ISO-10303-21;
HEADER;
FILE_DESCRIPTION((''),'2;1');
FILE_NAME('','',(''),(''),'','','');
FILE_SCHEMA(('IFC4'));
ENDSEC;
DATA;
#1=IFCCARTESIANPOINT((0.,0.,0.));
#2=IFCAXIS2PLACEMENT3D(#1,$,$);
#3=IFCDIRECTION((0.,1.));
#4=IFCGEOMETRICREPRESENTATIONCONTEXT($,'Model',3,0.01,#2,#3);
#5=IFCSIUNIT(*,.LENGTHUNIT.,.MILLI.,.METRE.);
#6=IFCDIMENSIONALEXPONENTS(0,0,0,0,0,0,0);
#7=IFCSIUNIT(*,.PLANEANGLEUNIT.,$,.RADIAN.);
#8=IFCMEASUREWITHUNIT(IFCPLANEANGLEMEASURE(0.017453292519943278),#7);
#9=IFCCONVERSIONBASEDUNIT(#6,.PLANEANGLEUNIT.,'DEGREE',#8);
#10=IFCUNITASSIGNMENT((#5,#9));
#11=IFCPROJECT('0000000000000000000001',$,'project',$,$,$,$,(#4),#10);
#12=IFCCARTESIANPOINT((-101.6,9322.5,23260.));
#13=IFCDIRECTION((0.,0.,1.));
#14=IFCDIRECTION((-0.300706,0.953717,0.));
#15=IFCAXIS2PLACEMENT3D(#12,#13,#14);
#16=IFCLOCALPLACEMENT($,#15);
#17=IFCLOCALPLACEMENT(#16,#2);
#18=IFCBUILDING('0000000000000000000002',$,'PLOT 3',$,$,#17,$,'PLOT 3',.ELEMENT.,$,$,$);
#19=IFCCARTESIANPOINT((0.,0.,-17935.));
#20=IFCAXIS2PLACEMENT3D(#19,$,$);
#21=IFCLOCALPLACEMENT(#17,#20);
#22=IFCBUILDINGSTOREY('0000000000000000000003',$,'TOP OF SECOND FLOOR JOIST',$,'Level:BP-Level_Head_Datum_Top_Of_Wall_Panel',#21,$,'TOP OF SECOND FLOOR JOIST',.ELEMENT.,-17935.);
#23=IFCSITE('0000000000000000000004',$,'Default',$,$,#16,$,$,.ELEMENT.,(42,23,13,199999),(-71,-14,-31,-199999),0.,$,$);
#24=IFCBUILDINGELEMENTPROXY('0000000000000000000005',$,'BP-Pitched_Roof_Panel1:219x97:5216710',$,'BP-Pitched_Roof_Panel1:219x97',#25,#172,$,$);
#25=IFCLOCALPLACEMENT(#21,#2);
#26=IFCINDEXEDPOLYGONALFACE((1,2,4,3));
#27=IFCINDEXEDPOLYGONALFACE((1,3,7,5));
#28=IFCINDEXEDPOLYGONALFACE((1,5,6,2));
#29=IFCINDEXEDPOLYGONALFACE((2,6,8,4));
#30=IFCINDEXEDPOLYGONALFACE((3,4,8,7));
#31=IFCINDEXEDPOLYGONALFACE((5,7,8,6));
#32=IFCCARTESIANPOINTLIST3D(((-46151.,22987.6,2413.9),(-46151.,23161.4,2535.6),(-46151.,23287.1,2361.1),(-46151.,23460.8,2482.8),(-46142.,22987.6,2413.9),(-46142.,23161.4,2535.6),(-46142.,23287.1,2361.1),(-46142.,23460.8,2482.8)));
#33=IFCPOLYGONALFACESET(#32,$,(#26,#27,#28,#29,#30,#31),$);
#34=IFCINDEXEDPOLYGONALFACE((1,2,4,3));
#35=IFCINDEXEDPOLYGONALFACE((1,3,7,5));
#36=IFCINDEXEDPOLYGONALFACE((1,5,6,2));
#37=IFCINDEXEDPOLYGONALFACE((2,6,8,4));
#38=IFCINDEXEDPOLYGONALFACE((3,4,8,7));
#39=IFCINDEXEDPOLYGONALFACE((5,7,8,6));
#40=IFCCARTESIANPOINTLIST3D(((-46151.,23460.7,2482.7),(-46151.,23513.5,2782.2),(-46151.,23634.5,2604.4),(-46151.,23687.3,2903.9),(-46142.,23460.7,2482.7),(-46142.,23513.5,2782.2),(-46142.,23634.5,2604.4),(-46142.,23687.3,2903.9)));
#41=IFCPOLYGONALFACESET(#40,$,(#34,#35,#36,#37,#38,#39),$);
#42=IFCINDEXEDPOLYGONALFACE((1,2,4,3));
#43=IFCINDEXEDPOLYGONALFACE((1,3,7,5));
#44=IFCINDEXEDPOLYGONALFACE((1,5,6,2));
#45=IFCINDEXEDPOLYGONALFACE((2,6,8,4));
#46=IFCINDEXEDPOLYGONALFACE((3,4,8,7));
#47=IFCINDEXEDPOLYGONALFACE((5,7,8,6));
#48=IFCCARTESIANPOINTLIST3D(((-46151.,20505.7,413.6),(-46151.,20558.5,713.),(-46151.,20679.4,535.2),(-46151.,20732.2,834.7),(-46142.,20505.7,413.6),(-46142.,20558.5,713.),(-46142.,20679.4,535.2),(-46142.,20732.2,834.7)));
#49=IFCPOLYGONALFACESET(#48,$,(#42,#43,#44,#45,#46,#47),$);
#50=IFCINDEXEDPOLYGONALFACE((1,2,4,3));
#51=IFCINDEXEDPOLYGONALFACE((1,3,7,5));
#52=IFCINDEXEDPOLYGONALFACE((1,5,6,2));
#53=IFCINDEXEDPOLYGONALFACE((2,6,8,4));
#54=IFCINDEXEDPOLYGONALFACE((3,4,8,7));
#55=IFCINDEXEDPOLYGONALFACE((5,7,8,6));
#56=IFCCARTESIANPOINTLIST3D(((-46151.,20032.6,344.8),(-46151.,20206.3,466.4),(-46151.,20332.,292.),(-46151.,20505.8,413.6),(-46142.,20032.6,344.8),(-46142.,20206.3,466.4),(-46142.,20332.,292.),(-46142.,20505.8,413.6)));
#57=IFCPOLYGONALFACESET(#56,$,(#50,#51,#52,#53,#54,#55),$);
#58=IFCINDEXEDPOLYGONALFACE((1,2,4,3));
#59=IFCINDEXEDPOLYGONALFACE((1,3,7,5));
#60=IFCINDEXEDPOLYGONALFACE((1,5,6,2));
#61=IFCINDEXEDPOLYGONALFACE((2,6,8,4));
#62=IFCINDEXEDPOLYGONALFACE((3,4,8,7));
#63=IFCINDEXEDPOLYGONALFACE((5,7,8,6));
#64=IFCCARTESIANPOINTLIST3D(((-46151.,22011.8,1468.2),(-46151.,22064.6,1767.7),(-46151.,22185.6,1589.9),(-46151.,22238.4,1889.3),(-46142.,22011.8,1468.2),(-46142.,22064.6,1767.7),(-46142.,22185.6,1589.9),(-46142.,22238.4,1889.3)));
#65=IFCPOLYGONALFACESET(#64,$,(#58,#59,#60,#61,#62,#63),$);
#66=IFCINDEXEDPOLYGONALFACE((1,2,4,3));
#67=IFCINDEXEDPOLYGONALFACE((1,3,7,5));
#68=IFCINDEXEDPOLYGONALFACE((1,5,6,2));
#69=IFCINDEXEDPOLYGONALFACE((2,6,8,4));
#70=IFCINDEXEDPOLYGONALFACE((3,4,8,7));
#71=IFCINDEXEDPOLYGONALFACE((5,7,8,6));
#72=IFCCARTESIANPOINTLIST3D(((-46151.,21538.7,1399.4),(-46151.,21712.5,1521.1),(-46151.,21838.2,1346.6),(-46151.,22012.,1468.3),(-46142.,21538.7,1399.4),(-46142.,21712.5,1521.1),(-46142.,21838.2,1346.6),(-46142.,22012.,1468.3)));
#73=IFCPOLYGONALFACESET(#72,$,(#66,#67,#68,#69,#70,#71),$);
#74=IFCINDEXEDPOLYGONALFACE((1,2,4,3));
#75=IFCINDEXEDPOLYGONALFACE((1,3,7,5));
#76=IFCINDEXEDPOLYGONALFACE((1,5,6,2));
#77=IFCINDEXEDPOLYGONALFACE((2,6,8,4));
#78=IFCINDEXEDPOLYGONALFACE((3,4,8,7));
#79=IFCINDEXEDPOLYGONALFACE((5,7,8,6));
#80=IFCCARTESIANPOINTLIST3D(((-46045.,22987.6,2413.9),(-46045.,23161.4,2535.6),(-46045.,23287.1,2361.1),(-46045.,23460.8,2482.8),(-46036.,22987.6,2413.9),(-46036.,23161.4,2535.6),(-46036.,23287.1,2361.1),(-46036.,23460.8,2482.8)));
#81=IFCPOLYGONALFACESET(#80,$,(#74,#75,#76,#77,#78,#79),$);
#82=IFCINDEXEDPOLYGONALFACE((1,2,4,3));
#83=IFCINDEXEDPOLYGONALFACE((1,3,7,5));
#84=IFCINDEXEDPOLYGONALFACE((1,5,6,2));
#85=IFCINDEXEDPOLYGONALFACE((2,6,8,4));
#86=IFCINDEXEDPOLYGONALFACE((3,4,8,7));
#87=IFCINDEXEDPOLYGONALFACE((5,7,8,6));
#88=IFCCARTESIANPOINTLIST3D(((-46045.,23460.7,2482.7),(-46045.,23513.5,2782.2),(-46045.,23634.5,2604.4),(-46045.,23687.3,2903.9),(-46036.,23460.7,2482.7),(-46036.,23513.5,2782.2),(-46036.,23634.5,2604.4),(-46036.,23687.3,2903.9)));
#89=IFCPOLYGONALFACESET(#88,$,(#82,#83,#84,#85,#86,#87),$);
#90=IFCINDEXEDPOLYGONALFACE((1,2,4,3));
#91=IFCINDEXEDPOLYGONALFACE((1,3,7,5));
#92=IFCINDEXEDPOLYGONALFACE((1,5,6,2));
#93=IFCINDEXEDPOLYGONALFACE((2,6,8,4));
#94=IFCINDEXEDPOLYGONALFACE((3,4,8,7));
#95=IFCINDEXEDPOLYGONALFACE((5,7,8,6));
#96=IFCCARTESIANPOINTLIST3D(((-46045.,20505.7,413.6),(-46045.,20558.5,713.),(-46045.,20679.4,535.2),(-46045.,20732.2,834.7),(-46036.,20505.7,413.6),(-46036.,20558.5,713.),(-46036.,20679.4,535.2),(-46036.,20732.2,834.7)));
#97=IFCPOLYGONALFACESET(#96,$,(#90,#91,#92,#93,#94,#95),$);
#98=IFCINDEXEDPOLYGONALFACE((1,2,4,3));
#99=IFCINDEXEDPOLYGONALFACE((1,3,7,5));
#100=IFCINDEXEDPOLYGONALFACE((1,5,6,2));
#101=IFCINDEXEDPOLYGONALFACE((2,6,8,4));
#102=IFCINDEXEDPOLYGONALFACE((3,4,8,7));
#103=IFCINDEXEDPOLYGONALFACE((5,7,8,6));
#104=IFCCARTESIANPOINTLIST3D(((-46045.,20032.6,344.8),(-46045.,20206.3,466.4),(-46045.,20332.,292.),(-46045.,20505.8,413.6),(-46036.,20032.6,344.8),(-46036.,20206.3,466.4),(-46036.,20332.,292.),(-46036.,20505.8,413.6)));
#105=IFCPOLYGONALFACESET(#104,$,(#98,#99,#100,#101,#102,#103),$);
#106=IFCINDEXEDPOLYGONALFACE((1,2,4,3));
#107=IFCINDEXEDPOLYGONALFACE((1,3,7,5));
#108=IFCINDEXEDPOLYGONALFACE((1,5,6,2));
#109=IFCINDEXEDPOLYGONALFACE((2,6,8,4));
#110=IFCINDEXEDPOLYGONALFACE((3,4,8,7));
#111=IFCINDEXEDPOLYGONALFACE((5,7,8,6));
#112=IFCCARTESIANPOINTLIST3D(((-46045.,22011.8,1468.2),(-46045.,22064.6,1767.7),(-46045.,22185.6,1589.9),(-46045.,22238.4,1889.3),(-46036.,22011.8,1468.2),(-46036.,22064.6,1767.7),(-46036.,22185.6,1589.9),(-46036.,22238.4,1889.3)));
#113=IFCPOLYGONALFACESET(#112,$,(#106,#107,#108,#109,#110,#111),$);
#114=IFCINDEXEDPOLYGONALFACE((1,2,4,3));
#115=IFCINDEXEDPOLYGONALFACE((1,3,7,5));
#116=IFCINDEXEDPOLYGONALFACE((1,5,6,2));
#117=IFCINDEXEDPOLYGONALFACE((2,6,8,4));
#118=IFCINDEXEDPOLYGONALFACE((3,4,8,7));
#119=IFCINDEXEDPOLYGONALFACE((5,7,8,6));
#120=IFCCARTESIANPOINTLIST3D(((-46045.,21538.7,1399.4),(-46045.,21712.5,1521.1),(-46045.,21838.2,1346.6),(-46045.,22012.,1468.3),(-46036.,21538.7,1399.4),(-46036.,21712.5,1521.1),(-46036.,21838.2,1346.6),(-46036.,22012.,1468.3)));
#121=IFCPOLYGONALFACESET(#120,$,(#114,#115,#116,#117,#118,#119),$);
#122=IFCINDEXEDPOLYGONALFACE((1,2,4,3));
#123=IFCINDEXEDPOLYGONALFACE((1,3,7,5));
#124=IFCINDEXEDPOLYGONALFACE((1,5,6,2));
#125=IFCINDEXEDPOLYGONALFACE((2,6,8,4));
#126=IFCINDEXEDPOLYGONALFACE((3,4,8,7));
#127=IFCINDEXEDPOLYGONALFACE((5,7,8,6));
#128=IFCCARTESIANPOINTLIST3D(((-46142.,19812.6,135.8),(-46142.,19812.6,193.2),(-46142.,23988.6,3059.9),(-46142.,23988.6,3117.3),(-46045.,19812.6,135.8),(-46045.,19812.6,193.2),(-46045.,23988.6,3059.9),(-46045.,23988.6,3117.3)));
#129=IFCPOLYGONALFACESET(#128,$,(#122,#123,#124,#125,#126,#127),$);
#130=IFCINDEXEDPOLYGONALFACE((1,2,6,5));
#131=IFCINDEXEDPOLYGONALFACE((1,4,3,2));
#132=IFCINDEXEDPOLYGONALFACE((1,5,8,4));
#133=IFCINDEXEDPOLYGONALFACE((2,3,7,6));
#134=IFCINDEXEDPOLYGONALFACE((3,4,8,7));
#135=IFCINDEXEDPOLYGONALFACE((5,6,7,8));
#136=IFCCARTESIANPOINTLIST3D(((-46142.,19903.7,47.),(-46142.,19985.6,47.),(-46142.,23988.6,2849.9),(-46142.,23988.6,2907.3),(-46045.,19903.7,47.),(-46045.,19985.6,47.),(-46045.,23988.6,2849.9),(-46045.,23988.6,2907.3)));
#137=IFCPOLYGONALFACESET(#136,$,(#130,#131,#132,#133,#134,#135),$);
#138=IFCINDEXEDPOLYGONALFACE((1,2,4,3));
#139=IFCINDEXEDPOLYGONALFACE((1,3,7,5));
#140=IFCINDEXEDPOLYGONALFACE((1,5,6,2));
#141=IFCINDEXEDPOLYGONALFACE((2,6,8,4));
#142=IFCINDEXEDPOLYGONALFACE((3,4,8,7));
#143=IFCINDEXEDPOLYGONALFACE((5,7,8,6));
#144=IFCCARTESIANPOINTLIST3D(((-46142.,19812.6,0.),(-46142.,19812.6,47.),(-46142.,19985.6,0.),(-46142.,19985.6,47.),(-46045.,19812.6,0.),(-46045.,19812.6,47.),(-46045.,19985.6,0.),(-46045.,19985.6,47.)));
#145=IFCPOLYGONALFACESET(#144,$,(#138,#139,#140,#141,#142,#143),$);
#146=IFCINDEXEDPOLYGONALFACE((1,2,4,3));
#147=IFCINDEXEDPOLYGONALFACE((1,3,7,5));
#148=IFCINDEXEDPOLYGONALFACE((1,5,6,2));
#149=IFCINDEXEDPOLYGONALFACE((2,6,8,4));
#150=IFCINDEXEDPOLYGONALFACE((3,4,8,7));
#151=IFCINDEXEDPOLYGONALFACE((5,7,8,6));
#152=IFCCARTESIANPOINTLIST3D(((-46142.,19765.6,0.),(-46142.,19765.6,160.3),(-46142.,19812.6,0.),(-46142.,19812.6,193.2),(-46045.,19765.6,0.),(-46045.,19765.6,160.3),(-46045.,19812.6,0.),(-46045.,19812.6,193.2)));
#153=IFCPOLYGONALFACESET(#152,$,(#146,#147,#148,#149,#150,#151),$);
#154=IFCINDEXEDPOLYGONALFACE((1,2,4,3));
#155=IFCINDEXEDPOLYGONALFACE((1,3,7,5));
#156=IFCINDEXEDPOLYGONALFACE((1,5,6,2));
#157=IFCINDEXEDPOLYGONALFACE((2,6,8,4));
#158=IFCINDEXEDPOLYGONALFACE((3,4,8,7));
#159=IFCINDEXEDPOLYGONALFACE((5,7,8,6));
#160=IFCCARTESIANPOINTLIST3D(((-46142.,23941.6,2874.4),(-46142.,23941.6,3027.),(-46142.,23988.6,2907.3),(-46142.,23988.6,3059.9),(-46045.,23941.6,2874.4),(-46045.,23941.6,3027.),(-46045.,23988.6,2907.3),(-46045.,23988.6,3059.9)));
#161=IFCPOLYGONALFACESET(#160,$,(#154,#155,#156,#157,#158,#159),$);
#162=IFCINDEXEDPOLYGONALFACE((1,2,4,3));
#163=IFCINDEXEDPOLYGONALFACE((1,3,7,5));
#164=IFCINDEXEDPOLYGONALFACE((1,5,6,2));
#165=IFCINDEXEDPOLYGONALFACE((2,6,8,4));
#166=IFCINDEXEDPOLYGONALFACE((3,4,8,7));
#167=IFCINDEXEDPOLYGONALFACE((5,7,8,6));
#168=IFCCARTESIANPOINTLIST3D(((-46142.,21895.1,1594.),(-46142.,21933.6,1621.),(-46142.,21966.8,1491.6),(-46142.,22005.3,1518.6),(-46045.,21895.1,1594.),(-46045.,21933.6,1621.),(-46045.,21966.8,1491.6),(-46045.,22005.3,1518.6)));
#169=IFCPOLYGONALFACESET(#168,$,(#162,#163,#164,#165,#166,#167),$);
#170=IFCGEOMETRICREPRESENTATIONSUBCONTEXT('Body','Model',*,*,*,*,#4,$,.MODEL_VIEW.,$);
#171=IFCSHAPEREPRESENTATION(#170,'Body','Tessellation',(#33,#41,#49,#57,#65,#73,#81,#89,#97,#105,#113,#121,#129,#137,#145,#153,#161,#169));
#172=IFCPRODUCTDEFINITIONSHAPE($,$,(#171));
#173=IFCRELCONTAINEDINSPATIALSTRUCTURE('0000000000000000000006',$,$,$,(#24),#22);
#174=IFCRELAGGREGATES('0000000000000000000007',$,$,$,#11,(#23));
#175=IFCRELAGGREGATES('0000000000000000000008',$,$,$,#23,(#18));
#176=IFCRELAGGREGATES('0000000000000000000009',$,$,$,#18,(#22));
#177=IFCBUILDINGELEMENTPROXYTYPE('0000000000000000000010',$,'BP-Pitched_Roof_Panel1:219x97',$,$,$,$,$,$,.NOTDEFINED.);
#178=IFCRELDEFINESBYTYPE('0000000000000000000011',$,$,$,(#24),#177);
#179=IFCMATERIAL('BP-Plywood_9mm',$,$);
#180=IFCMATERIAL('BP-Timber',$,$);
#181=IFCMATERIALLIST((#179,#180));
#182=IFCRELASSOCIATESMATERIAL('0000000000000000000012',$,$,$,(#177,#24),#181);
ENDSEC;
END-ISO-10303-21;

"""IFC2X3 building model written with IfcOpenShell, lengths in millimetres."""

from ifc_helpers import new_model, entity, si_unit, converted_unit, direction, frame, frame_2d, origin, origin_2d_with_axis, place, context, subcontext, project, spatial, polyline, rectangle, outline, extrude, source, transform, mapped, material, material_list, type_object, type_shapes, element, save


model = new_model("IFC2X3")

# Units and contexts
model_context = context("Model", 3, precision=0.01, world=origin(), true_north=direction((0.0, 1.0)))
body_context = subcontext(model_context, "Body", "Model", "MODEL_VIEW")
ifc_project = project(units=[si_unit("LENGTHUNIT", "METRE", prefix="MILLI"), converted_unit("PLANEANGLEUNIT", "DEGREE", entity("IfcPlaneAngleMeasure", 0.017453292519943278), si_unit("PLANEANGLEUNIT", "RADIAN"), dimensions=[0, 0, 0, 0, 0, 0, 0])], contexts=[model_context])

# Site, building, storey
site_placement = place(None, frame((-101.6, 9322.5, 23260.0), z_axis=(0.0, 0.0, 1.0), x_axis=(-0.300706, 0.953717, 0.0)))
site = spatial("IfcSite", under=ifc_project, at=site_placement, Name="Default", CompositionType="ELEMENT", RefLatitude=(42, 23, 13, 199999), RefLongitude=(-71, -14, -31, -199999), RefElevation=0.0)
building_placement = place(site_placement, origin())
building = spatial("IfcBuilding", under=site, at=building_placement, Name="PLOT 3", LongName="PLOT 3", CompositionType="ELEMENT")
storey_placement = place(building_placement, frame((0.0, 0.0, -17935.0)))
storey = spatial("IfcBuildingStorey", under=building, at=storey_placement, Name="TOP OF SECOND FLOOR JOIST", ObjectType="Level:BP-Level_Head_Datum_Top_Of_Wall_Panel", LongName="TOP OF SECOND FLOOR JOIST", CompositionType="ELEMENT", Elevation=-17935.0)

# Building element proxy
ifc_material_1 = material(Name="BP-Timber")
ifc_material_2 = material(Name="BP-Plywood_9mm")
ifc_material_list = material_list([ifc_material_2, ifc_material_1])
building_element_proxy_type_1 = type_object("IfcBuildingElementProxyType", Name="BP-Pitched_Roof_Panel1:219x97", PredefinedType="NOTDEFINED", material=ifc_material_list)
shared_shape_1 = source(origin(), body_context, "Body", "SweptSolid", [
    extrude(outline(polyline([(-77.0, -75.0), (227.0, -75.0), (77.0, 75.0), (-227.0, 75.0), (-77.0, -75.0)])), frame((36.3, 3947.0, 2448.4), z_axis=(0.0, 1.0, 0.0), x_axis=(-0.984808, 0.0, 0.173648)), (0.0, 0.0, 1.0), 9.0),
    extrude(outline(polyline([(1.4, -107.5), (213.6, -107.5), (-1.4, 107.5), (-213.6, 107.5), (1.4, -107.5)])), frame((386.1, 3947.0, 2693.3), z_axis=(0.0, 1.0, 0.0), x_axis=(-0.819152, 0.0, -0.573576)), (0.0, 0.0, 1.0), 9.0),
    extrude(outline(polyline([(1.4, -107.5), (213.6, -107.5), (-1.4, 107.5), (-213.6, 107.5), (1.4, -107.5)])), frame((-2569.0, 3947.0, 624.1), z_axis=(0.0, 1.0, 0.0), x_axis=(-0.819152, 0.0, -0.573576)), (0.0, 0.0, 1.0), 9.0),
    extrude(outline(polyline([(-77.0, -75.0), (227.0, -75.0), (77.0, 75.0), (-227.0, 75.0), (-77.0, -75.0)])), frame((-2918.8, 3947.0, 379.2), z_axis=(0.0, 1.0, 0.0), x_axis=(-0.984808, 0.0, 0.173648)), (0.0, 0.0, 1.0), 9.0),
    extrude(outline(polyline([(1.4, -107.5), (213.6, -107.5), (-1.4, 107.5), (-213.6, 107.5), (1.4, -107.5)])), frame((-1062.8, 3947.0, 1678.8), z_axis=(0.0, 1.0, 0.0), x_axis=(-0.819152, 0.0, -0.573576)), (0.0, 0.0, 1.0), 9.0),
    extrude(outline(polyline([(-77.0, -75.0), (227.0, -75.0), (77.0, 75.0), (-227.0, 75.0), (-77.0, -75.0)])), frame((-1412.6, 3947.0, 1433.9), z_axis=(0.0, 1.0, 0.0), x_axis=(-0.984808, 0.0, 0.173648)), (0.0, 0.0, 1.0), 9.0),
    extrude(outline(polyline([(-77.0, -75.0), (227.0, -75.0), (77.0, 75.0), (-227.0, 75.0), (-77.0, -75.0)])), frame((36.3, 3841.0, 2448.4), z_axis=(0.0, 1.0, 0.0), x_axis=(-0.984808, 0.0, 0.173648)), (0.0, 0.0, 1.0), 9.0),
    extrude(outline(polyline([(1.4, -107.5), (213.6, -107.5), (-1.4, 107.5), (-213.6, 107.5), (1.4, -107.5)])), frame((386.1, 3841.0, 2693.3), z_axis=(0.0, 1.0, 0.0), x_axis=(-0.819152, 0.0, -0.573576)), (0.0, 0.0, 1.0), 9.0),
    extrude(outline(polyline([(1.4, -107.5), (213.6, -107.5), (-1.4, 107.5), (-213.6, 107.5), (1.4, -107.5)])), frame((-2569.0, 3841.0, 624.1), z_axis=(0.0, 1.0, 0.0), x_axis=(-0.819152, 0.0, -0.573576)), (0.0, 0.0, 1.0), 9.0),
    extrude(outline(polyline([(-77.0, -75.0), (227.0, -75.0), (77.0, 75.0), (-227.0, 75.0), (-77.0, -75.0)])), frame((-2918.8, 3841.0, 379.2), z_axis=(0.0, 1.0, 0.0), x_axis=(-0.984808, 0.0, 0.173648)), (0.0, 0.0, 1.0), 9.0),
    extrude(outline(polyline([(1.4, -107.5), (213.6, -107.5), (-1.4, 107.5), (-213.6, 107.5), (1.4, -107.5)])), frame((-1062.8, 3841.0, 1678.8), z_axis=(0.0, 1.0, 0.0), x_axis=(-0.819152, 0.0, -0.573576)), (0.0, 0.0, 1.0), 9.0),
    extrude(outline(polyline([(-77.0, -75.0), (227.0, -75.0), (77.0, 75.0), (-227.0, 75.0), (-77.0, -75.0)])), frame((-1412.6, 3841.0, 1433.9), z_axis=(0.0, 1.0, 0.0), x_axis=(-0.984808, 0.0, 0.173648)), (0.0, 0.0, 1.0), 9.0),
    extrude(outline(polyline([(-1490.7, -2088.0), (-1433.3, -2088.0), (1490.7, 2088.0), (1433.3, 2088.0), (-1490.7, -2088.0)])), frame((-1287.3, 3850.0, 1626.6), z_axis=(0.0, 1.0, 0.0), x_axis=(0.0, 0.0, -1.0)), (0.0, 0.0, 1.0), 97.0),
    extrude(outline(polyline([(-1444.5, -2022.0), (-1387.1, -2022.0), (1415.8, 1981.0), (1415.8, 2063.0), (-1444.5, -2022.0)])), frame((-1221.3, 3850.0, 1462.8), z_axis=(0.0, 1.0, 0.0), x_axis=(0.0, 0.0, -1.0)), (0.0, 0.0, 1.0), 97.0),
    extrude(rectangle(XDim=97.0, YDim=173.0, at=origin_2d_with_axis()), frame((-3288.8, 3898.5, 0.0), z_axis=(0.0, 0.0, 1.0), x_axis=(0.0, 1.0, 0.0)), (0.0, 0.0, 1.0), 47.0),
    extrude(outline(polyline([(22.0, -72.4), (79.4, -72.4), (-31.4, 85.9), (-69.9, 58.9), (22.0, -72.4)])), frame((-3398.8, 3850.0, 88.4), z_axis=(0.0, 1.0, 0.0), x_axis=(0.819152, 0.0, 0.573576)), (0.0, 0.0, 1.0), 97.0),
    extrude(outline(polyline([(15.1, -62.5), (72.5, -62.5), (-15.1, 62.5), (-72.5, 62.5), (15.1, -62.5)])), frame((777.2, 3850.0, 2967.2), z_axis=(0.0, 1.0, 0.0), x_axis=(0.819152, 0.0, 0.573576)), (0.0, 0.0, 1.0), 97.0),
    extrude(rectangle(XDim=47.0, YDim=97.0, at=frame_2d((0.0, 0.0), x_axis=(0.0, 1.0))), frame((-1201.9, 3898.5, 1505.1), z_axis=(-0.573576, 0.0, 0.819152), x_axis=(0.0, 1.0, 0.0)), (0.0, 0.0, 1.0), 125.0),
])
type_shapes(building_element_proxy_type_1, [shared_shape_1])
for number, where, z_axis, x_axis, name in (
    (1, (-42195.0, 23187.9, 0.0), (0.0, 0.0, 1.0), (0.0, 1.0, 0.0), "BP-Pitched_Roof_Panel1:219x97:5216710"),
):
    element("IfcBuildingElementProxy", number, at=place(storey_placement, frame(where, z_axis=z_axis, x_axis=x_axis)), inside=storey, type_object=building_element_proxy_type_1, material=ifc_material_list, Name=name, ObjectType="BP-Pitched_Roof_Panel1:219x97", context=body_context, shape_type="MappedRepresentation", body=[
        mapped(shared_shape_1, transform((0.0, 0.0, 0.0), scale=1.0)),
    ])

save(model, "model.ifc")
